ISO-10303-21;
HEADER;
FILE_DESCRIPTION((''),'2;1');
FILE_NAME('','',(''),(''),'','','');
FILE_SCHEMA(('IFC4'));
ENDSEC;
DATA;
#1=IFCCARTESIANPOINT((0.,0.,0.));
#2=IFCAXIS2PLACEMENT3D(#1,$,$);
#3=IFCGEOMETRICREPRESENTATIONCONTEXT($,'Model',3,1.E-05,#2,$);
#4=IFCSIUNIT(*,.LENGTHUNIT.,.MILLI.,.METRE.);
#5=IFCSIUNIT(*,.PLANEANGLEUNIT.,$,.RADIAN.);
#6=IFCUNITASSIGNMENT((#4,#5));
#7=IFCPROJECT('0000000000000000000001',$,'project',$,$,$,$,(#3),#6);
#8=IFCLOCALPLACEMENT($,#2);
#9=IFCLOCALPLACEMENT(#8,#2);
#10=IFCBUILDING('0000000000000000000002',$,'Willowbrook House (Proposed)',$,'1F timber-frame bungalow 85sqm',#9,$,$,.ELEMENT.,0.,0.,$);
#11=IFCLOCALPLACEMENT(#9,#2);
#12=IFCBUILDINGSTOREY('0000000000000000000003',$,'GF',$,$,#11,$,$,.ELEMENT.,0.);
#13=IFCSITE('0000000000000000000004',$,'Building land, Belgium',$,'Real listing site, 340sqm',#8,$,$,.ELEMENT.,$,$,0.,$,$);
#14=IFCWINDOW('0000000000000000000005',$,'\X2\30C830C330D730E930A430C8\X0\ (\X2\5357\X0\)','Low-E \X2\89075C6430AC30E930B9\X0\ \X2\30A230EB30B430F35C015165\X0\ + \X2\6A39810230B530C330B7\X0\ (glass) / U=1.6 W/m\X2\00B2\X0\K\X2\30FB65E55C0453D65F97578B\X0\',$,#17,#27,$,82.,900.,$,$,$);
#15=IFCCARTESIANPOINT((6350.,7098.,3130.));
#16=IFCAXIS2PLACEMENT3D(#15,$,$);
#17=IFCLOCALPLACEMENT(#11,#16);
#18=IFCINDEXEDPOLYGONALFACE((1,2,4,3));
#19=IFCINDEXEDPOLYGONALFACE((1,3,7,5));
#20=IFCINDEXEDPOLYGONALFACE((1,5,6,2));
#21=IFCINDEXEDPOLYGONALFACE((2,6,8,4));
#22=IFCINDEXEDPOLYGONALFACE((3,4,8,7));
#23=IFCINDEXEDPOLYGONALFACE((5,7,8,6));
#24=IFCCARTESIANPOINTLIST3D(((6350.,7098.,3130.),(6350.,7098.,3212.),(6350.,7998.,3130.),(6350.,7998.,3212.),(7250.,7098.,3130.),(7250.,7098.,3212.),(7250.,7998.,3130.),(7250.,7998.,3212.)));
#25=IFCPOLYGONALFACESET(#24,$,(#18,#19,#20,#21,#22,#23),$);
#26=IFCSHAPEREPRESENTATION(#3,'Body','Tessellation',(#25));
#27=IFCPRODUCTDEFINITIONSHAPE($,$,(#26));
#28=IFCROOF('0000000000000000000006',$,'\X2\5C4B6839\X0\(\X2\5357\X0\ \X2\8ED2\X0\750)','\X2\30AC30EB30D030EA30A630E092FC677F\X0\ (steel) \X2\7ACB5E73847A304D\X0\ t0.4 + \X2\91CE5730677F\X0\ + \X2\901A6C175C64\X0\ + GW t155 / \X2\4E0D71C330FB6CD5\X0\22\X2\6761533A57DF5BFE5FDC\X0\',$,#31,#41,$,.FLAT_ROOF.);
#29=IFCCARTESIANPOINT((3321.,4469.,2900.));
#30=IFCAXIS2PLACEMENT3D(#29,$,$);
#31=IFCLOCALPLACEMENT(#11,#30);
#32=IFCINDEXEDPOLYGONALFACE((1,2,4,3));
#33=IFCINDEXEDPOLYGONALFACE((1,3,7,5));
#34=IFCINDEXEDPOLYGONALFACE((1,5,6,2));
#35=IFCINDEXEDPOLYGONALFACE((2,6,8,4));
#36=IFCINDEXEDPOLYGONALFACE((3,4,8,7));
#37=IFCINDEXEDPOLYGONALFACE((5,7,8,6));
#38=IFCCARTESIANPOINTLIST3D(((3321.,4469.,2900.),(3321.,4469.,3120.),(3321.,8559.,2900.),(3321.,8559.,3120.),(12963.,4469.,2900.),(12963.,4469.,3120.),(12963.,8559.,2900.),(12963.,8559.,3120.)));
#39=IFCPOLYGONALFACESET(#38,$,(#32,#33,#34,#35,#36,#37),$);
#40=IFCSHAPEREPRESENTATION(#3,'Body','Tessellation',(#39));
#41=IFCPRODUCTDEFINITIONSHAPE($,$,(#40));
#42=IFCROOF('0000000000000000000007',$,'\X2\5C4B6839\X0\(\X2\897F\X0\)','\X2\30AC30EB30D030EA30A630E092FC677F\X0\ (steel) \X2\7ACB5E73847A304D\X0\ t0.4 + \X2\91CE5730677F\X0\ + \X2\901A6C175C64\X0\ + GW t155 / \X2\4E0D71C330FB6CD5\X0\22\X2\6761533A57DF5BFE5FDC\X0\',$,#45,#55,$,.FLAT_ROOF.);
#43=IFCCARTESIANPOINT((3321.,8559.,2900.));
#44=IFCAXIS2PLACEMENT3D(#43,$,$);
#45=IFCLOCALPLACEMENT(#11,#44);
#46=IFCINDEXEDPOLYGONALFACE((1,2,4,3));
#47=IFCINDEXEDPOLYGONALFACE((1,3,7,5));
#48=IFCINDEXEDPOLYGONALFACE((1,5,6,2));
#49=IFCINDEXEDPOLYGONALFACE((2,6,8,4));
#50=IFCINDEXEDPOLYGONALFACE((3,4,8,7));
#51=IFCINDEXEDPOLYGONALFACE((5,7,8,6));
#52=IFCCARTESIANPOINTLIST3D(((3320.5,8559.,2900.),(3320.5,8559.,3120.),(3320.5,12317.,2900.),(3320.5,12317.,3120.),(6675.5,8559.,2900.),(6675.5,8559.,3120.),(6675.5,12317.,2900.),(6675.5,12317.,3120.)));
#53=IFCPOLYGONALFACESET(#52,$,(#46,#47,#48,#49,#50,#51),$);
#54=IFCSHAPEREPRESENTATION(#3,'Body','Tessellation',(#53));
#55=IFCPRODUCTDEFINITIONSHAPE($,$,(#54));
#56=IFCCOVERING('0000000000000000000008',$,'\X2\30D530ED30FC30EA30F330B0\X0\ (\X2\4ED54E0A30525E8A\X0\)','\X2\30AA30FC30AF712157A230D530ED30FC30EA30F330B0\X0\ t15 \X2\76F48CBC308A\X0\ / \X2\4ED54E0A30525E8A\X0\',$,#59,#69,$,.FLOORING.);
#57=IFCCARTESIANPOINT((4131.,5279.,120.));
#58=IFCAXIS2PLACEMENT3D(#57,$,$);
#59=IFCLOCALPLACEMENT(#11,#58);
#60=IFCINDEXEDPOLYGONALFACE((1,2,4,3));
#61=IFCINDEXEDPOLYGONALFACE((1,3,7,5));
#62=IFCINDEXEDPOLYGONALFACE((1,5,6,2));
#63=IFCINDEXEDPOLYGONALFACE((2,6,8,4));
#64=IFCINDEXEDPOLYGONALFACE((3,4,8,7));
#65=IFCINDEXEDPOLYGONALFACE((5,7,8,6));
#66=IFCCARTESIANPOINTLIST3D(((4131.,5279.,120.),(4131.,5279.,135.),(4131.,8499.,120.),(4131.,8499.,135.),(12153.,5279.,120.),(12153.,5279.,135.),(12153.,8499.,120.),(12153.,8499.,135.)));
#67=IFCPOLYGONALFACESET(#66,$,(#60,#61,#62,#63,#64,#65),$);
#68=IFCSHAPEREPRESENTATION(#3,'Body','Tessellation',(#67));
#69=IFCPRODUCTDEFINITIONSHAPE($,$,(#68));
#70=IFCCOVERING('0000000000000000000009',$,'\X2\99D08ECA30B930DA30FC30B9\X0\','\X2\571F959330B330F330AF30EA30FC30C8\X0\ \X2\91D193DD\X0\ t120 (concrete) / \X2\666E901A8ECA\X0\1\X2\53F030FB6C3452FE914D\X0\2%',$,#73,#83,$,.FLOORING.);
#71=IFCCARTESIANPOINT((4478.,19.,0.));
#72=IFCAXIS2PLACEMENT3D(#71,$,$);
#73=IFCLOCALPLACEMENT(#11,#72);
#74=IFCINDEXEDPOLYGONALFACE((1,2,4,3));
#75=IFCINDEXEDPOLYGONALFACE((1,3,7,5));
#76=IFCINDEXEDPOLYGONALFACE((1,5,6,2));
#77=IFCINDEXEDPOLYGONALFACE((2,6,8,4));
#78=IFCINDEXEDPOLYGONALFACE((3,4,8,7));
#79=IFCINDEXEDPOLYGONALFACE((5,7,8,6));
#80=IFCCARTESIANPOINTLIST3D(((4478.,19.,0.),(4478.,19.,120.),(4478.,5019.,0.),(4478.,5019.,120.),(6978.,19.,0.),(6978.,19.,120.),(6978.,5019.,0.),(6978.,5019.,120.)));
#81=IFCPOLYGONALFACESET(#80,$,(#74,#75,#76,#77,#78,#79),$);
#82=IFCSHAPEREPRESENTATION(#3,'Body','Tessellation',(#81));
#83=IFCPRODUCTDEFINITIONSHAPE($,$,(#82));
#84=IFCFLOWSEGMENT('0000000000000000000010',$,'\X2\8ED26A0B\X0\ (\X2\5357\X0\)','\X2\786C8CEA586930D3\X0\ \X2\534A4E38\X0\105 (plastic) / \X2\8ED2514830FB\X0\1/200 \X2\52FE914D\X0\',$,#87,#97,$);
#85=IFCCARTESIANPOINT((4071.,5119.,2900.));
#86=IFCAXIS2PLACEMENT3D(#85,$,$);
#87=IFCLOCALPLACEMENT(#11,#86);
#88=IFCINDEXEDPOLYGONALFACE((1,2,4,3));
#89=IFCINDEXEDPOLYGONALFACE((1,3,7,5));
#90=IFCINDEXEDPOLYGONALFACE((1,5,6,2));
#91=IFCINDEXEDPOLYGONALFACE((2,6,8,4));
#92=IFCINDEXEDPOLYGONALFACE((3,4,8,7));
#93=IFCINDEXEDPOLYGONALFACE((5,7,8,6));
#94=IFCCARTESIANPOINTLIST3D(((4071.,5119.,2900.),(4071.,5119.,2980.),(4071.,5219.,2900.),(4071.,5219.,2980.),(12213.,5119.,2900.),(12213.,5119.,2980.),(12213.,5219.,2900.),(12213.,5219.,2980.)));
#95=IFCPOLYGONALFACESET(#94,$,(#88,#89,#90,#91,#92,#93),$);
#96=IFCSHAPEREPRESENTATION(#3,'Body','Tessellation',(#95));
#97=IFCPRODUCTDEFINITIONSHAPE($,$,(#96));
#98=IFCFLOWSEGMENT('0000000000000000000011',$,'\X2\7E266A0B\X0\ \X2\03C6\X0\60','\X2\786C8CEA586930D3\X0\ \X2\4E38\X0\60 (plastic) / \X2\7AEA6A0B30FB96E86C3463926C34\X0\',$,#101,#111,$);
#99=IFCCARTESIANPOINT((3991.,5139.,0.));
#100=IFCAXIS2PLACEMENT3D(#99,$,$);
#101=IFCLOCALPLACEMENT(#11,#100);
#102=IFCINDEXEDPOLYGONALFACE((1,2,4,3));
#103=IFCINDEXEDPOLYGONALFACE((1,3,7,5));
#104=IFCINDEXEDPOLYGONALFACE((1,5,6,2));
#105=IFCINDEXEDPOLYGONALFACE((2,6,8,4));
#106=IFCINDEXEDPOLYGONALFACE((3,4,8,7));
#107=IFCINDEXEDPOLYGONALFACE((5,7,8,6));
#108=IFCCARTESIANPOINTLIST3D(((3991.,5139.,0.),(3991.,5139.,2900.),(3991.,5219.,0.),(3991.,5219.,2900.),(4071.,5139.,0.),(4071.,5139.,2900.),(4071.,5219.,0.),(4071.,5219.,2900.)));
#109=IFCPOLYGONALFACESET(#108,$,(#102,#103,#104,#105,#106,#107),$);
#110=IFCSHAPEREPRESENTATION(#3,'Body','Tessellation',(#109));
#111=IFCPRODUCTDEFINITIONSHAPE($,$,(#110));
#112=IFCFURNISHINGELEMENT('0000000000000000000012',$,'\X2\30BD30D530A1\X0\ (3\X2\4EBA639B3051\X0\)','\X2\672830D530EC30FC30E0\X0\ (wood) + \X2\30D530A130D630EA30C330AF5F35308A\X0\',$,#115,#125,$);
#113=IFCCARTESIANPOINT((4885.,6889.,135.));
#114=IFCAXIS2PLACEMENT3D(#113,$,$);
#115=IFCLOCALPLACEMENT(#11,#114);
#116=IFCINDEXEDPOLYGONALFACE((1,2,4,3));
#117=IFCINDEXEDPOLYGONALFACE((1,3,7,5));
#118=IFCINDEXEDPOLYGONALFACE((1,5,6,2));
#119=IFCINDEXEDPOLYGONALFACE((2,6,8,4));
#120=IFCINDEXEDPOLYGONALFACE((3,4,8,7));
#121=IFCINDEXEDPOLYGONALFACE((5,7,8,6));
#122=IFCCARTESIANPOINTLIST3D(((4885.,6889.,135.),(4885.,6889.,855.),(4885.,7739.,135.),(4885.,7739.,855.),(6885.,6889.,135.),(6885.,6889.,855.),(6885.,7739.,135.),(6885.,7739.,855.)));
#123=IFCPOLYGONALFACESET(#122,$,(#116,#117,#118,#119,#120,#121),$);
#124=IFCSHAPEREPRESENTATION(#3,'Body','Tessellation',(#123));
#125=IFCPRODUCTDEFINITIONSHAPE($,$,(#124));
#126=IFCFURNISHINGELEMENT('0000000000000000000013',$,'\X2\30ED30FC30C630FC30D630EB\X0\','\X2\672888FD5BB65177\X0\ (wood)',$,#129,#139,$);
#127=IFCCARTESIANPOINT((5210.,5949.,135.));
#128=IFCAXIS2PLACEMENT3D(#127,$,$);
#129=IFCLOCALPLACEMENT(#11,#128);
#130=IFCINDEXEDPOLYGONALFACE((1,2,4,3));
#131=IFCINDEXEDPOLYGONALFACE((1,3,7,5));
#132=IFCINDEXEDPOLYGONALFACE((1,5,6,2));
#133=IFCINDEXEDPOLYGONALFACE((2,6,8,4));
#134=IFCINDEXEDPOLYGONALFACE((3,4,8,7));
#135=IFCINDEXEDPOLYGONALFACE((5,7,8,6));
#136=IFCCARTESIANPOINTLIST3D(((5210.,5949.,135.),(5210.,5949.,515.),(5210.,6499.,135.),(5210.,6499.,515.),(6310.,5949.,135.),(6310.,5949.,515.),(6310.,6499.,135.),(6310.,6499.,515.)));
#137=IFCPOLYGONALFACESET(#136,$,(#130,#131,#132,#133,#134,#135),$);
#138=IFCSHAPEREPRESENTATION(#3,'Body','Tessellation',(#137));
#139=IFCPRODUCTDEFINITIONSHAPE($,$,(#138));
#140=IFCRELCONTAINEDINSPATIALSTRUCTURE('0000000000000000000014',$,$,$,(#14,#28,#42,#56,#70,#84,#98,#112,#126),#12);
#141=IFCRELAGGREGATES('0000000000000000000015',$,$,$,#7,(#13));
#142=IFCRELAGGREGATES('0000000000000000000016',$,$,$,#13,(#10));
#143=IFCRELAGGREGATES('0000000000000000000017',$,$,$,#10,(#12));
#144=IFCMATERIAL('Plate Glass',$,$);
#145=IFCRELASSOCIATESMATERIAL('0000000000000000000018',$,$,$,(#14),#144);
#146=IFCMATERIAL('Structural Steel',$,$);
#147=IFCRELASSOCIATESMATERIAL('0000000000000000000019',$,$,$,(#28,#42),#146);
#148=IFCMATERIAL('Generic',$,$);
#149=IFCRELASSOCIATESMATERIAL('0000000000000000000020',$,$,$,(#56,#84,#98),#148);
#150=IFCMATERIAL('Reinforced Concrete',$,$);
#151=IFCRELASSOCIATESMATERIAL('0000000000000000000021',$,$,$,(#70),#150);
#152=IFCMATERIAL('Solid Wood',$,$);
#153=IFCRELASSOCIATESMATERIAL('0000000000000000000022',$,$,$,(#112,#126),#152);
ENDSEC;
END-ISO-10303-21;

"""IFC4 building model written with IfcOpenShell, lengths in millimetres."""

from ifc_helpers import new_model, si_unit, frame, frame_2d, origin, place, context, project, spatial, rectangle, extrude, material, element, save


model = new_model("IFC4")

# Units and contexts
model_context = context("Model", 3, precision=1e-05, world=origin())
ifc_project = project(units=[si_unit("LENGTHUNIT", "METRE", prefix="MILLI"), si_unit("PLANEANGLEUNIT", "RADIAN")], contexts=[model_context])

# Site, building, storey
site_placement = place(None, origin())
site = spatial("IfcSite", under=ifc_project, at=site_placement, Name="Building land, Belgium", ObjectType="Real listing site, 340sqm", CompositionType="ELEMENT", RefElevation=0.0)
building_placement = place(site_placement, origin())
building = spatial("IfcBuilding", under=site, at=building_placement, Name="Willowbrook House (Proposed)", ObjectType="1F timber-frame bungalow 85sqm", CompositionType="ELEMENT", ElevationOfRefHeight=0.0, ElevationOfTerrain=0.0)
storey_placement = place(building_placement, origin())
storey = spatial("IfcBuildingStorey", under=building, at=storey_placement, Name="GF", CompositionType="ELEMENT", Elevation=0.0)

# Shared definitions
ifc_material_1 = material(Name="Solid Wood")

# Shared definitions
ifc_material_2 = material(Name="Reinforced Concrete")

# Shared definitions
ifc_material_3 = material(Name="Plate Glass")

# Window
window_1_placement = place(storey_placement, frame((6350.0, 7098.0, 3130.0)))
element("IfcWindow", 1, at=window_1_placement, inside=storey, material=ifc_material_3, Name="トップライト (南)", Description="Low-E 複層ガラス アルゴン封入 + 樹脂サッシ (glass) / U=1.6 W/m²K・日射取得型", OverallHeight=82.0, OverallWidth=900.0, context=model_context, shape_type="SweptSolid", body=[
    extrude(rectangle(XDim=900.0, YDim=900.0, at=frame_2d((450.0, 450.0))), frame((6350.0, 7098.0, 3130.0)), (0.0, 0.0, 1.0), 82.0),
])

# Roofs
ifc_material_4 = material(Name="Structural Steel")
roof_1_placement = place(storey_placement, frame((3321.0, 4469.0, 2900.0)))
element("IfcRoof", 2, at=roof_1_placement, inside=storey, material=ifc_material_4, Name="屋根(南 軒750)", Description="ガルバリウム鋼板 (steel) 立平葺き t0.4 + 野地板 + 通気層 + GW t155 / 不燃・法22条区域対応", PredefinedType="FLAT_ROOF", context=model_context, shape_type="SweptSolid", body=[
    extrude(rectangle(XDim=9642.0, YDim=4090.0, at=frame_2d((4821.0, 2045.0))), frame((3321.0, 4469.0, 2900.0)), (0.0, 0.0, 1.0), 220.0),
])
roof_2_placement = place(storey_placement, frame((3321.0, 8559.0, 2900.0)))
element("IfcRoof", 3, at=roof_2_placement, inside=storey, material=ifc_material_4, Name="屋根(西)", Description="ガルバリウム鋼板 (steel) 立平葺き t0.4 + 野地板 + 通気層 + GW t155 / 不燃・法22条区域対応", PredefinedType="FLAT_ROOF", context=model_context, shape_type="SweptSolid", body=[
    extrude(rectangle(XDim=3355.0, YDim=3758.0, at=frame_2d((1677.0, 1879.0))), frame((3321.0, 8559.0, 2900.0)), (0.0, 0.0, 1.0), 220.0),
])

# Coverings
ifc_material_5 = material(Name="Generic")
covering_1_placement = place(storey_placement, frame((4131.0, 5279.0, 120.0)))
element("IfcCovering", 4, at=covering_1_placement, inside=storey, material=ifc_material_5, Name="フローリング (仕上げ床)", Description="オーク無垢フローリング t15 直貼り / 仕上げ床", PredefinedType="FLOORING", context=model_context, shape_type="SweptSolid", body=[
    extrude(rectangle(XDim=8022.0, YDim=3220.0, at=frame_2d((4011.0, 1610.0))), frame((4131.0, 5279.0, 120.0)), (0.0, 0.0, 1.0), 15.0),
])
covering_2_placement = place(storey_placement, frame((4478.0, 19.0, 0.0)))
element("IfcCovering", 5, at=covering_2_placement, inside=storey, material=ifc_material_2, Name="駐車スペース", Description="土間コンクリート 金鏝 t120 (concrete) / 普通車1台・水勾配2%", PredefinedType="FLOORING", context=model_context, shape_type="SweptSolid", body=[
    extrude(rectangle(XDim=2500.0, YDim=5000.0, at=frame_2d((1250.0, 2500.0))), frame((4478.0, 19.0, 0.0)), (0.0, 0.0, 1.0), 120.0),
])

# Flow segments
flow_segment_1_placement = place(storey_placement, frame((4071.0, 5119.0, 2900.0)))
element("IfcFlowSegment", 6, at=flow_segment_1_placement, inside=storey, material=ifc_material_5, Name="軒樋 (南)", Description="硬質塩ビ 半丸105 (plastic) / 軒先・1/200 勾配", context=model_context, shape_type="SweptSolid", body=[
    extrude(rectangle(XDim=8142.0, YDim=100.0, at=frame_2d((4071.0, 50.0))), frame((4071.0, 5119.0, 2900.0)), (0.0, 0.0, 1.0), 80.0),
])
flow_segment_2_placement = place(storey_placement, frame((3991.0, 5139.0, 0.0)))
element("IfcFlowSegment", 7, at=flow_segment_2_placement, inside=storey, material=ifc_material_5, Name="縦樋 φ60", Description="硬質塩ビ 丸60 (plastic) / 竪樋・雨水排水", context=model_context, shape_type="SweptSolid", body=[
    extrude(rectangle(XDim=80.0, YDim=80.0, at=frame_2d((40.0, 40.0))), frame((3991.0, 5139.0, 0.0)), (0.0, 0.0, 1.0), 2900.0),
])

# Furnishing elements
furnishing_1_placement = place(storey_placement, frame((4885.0, 6889.0, 135.0)))
element("IfcFurnishingElement", 8, at=furnishing_1_placement, inside=storey, material=ifc_material_1, Name="ソファ (3人掛け)", Description="木フレーム (wood) + ファブリック張り", context=model_context, shape_type="SweptSolid", body=[
    extrude(rectangle(XDim=2000.0, YDim=850.0, at=frame_2d((1000.0, 425.0))), frame((4885.0, 6889.0, 135.0)), (0.0, 0.0, 1.0), 720.0),
])
furnishing_2_placement = place(storey_placement, frame((5210.0, 5949.0, 135.0)))
element("IfcFurnishingElement", 9, at=furnishing_2_placement, inside=storey, material=ifc_material_1, Name="ローテーブル", Description="木製家具 (wood)", context=model_context, shape_type="SweptSolid", body=[
    extrude(rectangle(XDim=1100.0, YDim=550.0, at=frame_2d((550.0, 275.0))), frame((5210.0, 5949.0, 135.0)), (0.0, 0.0, 1.0), 380.0),
])

save(model, "model.ifc")
